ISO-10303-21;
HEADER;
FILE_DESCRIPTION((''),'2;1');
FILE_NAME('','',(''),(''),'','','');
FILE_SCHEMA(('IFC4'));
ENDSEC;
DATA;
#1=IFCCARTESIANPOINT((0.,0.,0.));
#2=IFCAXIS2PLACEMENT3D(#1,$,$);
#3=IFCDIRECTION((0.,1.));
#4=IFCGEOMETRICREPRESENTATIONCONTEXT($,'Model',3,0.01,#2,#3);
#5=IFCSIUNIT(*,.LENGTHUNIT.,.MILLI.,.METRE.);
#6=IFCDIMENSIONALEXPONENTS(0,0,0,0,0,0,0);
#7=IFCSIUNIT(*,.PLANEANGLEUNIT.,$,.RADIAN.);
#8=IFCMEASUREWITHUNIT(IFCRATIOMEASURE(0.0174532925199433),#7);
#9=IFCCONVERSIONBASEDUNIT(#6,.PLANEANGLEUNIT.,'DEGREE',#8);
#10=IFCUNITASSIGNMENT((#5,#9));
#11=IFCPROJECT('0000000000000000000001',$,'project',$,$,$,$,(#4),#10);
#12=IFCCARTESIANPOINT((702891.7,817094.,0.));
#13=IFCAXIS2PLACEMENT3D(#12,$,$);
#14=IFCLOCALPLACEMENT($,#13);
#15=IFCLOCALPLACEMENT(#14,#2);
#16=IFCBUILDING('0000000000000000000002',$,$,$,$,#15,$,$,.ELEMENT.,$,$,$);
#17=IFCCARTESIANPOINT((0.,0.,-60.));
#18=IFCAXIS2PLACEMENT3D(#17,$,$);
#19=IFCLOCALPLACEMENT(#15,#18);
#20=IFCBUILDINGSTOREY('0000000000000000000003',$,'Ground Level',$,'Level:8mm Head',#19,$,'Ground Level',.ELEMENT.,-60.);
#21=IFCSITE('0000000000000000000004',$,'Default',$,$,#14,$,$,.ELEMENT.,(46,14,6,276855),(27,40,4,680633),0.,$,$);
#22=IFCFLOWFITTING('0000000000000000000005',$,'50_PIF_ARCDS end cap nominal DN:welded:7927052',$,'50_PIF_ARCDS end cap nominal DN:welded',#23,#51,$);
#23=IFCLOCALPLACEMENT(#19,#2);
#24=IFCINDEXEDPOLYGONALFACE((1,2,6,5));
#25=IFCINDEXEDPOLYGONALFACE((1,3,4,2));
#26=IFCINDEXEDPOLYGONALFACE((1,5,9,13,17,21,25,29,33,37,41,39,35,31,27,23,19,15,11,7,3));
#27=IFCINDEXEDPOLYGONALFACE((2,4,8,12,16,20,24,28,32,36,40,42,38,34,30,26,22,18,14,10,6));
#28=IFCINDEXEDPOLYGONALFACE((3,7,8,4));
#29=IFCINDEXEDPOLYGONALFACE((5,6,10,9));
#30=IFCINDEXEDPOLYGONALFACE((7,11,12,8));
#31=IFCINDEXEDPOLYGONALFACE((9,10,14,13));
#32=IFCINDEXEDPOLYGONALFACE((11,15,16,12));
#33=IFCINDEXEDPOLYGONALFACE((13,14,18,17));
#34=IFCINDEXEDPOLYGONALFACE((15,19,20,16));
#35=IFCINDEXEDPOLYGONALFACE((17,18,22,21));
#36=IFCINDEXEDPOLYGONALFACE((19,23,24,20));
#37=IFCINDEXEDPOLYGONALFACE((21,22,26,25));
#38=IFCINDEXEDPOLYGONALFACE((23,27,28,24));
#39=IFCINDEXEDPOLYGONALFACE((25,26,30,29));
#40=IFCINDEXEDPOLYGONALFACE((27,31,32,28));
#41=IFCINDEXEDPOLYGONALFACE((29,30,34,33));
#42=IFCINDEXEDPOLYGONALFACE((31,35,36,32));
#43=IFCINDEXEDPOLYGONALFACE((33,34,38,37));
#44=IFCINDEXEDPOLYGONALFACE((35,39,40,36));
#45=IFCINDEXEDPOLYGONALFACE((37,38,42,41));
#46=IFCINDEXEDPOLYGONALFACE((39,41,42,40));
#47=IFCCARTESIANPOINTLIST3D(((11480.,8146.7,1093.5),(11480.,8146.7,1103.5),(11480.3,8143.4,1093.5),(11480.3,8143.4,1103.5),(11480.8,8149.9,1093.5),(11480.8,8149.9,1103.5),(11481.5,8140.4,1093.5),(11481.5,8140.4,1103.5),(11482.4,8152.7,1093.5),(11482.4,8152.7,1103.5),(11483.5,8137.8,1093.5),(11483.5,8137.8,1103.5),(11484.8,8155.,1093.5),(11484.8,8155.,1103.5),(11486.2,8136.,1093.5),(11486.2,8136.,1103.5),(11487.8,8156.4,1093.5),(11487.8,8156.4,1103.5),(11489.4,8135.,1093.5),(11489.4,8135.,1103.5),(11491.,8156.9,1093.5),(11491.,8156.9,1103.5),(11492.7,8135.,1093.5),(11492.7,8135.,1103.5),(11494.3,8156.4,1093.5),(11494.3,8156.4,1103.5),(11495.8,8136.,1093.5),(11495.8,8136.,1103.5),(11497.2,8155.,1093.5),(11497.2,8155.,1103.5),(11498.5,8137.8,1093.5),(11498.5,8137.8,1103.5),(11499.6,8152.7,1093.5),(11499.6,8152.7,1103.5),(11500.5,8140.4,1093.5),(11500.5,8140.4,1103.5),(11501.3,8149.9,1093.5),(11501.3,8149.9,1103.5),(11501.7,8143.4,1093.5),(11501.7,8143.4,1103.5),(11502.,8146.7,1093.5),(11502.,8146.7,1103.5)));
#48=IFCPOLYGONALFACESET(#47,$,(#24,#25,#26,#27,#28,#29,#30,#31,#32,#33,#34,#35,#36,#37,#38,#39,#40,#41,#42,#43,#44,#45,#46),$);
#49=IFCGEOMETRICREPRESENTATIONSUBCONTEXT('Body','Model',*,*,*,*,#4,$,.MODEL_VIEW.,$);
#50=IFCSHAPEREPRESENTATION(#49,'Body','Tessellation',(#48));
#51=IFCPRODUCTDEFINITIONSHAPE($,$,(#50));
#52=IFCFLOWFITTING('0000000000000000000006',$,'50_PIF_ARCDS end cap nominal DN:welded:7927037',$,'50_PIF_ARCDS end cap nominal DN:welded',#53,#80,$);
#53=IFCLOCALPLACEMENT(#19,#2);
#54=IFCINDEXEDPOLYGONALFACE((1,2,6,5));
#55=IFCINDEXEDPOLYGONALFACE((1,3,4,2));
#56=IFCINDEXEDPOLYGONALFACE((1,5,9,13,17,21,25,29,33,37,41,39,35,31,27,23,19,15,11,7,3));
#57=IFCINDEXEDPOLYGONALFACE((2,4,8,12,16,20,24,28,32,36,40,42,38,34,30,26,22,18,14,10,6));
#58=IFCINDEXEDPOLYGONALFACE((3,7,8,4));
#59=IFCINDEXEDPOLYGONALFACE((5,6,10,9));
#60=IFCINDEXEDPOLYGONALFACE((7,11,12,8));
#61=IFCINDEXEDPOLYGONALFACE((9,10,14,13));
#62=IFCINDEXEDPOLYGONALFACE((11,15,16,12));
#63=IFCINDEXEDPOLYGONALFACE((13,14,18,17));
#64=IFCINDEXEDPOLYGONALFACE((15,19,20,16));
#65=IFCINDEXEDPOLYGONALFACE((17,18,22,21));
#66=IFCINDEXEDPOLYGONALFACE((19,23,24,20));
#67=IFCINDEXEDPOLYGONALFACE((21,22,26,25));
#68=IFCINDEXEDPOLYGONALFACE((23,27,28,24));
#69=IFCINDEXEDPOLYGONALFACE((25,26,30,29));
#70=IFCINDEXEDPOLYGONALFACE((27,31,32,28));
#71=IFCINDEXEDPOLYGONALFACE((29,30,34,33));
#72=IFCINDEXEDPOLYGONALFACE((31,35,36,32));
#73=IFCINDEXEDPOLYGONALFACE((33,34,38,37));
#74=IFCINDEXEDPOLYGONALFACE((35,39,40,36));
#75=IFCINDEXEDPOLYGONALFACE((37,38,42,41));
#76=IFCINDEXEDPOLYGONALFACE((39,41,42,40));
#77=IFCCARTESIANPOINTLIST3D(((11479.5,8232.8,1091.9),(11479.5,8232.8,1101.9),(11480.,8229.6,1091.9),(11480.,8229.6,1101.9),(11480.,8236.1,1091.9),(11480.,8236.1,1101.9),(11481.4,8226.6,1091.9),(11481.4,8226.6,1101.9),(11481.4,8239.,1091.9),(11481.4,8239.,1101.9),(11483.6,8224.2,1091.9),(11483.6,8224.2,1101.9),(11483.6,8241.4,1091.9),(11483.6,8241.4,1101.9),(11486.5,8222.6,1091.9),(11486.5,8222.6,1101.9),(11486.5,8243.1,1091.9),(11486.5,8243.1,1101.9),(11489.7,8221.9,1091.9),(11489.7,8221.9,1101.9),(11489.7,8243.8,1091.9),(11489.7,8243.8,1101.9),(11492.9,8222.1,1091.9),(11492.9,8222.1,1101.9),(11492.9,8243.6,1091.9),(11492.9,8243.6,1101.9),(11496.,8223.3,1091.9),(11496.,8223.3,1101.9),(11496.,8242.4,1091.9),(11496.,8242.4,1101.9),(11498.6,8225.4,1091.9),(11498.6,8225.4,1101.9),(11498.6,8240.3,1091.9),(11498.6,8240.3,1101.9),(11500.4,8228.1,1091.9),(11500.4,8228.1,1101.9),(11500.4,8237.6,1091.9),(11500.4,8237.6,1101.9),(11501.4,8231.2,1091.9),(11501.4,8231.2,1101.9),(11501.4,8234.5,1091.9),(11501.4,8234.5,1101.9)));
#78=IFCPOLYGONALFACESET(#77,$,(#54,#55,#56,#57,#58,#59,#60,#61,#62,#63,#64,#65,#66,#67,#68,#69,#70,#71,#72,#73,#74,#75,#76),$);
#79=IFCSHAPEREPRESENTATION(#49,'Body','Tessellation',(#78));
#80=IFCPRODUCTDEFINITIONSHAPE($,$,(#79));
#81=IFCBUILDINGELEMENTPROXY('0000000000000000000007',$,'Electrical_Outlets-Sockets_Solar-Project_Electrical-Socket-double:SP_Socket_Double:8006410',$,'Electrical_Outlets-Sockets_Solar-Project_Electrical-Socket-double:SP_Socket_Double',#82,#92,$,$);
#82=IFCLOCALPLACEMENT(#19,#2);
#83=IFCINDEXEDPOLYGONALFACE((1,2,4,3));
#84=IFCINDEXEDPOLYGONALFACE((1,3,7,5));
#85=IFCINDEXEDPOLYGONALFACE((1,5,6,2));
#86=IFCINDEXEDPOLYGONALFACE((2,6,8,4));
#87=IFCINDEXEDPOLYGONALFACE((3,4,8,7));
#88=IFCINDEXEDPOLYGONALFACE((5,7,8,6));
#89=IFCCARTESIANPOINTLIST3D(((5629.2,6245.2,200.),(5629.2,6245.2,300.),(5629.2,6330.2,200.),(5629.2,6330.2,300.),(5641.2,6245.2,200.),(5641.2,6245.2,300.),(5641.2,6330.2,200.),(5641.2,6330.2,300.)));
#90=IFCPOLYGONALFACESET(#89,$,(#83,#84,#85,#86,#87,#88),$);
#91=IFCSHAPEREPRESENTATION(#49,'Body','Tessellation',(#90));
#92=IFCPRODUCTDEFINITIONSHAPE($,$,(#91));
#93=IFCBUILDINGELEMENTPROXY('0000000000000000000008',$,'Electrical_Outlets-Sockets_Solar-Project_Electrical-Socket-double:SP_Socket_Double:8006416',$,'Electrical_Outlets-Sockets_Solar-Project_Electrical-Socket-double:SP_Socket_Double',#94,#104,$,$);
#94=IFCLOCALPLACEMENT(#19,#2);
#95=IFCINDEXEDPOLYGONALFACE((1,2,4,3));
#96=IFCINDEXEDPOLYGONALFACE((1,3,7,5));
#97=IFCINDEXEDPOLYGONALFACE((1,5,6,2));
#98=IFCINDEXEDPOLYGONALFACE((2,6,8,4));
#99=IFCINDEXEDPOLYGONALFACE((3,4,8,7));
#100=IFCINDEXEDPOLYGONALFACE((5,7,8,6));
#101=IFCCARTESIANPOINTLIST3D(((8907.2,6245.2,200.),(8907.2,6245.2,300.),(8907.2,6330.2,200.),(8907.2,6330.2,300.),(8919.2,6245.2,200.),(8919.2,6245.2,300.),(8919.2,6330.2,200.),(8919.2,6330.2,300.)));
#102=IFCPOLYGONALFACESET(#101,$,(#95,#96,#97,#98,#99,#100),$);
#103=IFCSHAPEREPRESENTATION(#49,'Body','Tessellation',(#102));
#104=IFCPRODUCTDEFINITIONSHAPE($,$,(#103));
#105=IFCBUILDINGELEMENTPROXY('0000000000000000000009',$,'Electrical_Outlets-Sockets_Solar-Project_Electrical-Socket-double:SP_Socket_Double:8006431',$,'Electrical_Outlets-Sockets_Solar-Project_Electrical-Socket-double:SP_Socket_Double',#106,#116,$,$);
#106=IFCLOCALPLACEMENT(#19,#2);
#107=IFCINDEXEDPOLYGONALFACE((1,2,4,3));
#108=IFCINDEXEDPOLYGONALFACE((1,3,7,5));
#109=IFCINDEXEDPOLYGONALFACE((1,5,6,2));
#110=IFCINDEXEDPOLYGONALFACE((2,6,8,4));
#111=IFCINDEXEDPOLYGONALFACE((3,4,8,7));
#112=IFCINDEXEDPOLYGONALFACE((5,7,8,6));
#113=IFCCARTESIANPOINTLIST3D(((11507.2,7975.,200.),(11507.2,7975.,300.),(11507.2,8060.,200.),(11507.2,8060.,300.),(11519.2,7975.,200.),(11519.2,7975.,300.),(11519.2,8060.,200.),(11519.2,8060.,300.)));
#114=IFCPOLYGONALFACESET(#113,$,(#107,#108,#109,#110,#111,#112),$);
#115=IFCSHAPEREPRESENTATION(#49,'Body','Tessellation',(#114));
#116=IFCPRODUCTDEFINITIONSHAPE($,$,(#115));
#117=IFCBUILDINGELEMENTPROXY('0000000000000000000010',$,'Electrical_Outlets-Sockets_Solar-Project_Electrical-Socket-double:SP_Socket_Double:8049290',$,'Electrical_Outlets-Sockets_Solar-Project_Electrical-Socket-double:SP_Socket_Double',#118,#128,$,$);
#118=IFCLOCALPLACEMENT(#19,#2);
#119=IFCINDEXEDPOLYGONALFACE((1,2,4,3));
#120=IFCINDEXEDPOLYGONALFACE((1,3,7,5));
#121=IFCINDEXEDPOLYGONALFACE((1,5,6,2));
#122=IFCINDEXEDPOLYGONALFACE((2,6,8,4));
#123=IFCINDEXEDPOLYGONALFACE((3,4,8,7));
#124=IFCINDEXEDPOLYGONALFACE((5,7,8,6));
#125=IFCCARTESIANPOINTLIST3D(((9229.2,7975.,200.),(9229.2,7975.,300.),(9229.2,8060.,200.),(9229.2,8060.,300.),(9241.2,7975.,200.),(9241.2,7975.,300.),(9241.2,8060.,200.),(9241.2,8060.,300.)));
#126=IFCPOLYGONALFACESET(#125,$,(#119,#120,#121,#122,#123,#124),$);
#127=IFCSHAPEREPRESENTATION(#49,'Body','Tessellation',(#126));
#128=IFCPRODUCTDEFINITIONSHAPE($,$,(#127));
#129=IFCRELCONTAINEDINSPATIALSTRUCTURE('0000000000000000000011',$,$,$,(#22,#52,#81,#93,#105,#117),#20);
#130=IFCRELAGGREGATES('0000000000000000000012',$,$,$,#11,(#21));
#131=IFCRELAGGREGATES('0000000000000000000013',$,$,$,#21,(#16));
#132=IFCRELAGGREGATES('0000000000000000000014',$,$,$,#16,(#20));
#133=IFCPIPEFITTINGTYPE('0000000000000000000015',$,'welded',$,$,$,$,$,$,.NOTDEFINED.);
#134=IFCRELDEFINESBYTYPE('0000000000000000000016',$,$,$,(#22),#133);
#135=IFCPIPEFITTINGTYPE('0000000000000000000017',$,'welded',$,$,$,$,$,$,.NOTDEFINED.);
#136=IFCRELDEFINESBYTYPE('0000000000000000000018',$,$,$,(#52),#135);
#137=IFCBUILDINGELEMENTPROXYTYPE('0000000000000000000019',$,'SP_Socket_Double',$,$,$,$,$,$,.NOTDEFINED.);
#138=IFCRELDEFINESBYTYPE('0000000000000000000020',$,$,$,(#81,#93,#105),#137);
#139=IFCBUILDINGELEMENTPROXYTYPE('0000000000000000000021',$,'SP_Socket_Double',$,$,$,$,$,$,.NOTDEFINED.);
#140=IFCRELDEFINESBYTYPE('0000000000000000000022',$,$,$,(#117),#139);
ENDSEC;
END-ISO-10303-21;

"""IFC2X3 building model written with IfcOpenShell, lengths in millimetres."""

from ifc_helpers import new_model, entity, si_unit, converted_unit, direction, frame, frame_2d, origin, origin_2d_with_axis, place, context, subcontext, project, spatial, rectangle, circle, extrude, source, transform, mapped, type_object, type_shapes, element, save


model = new_model("IFC2X3")

# Units and contexts
model_context = context("Model", 3, precision=0.01, world=origin(), true_north=direction((0.0, 1.0)))
body_context = subcontext(model_context, "Body", "Model", "MODEL_VIEW")
ifc_project = project(units=[si_unit("LENGTHUNIT", "METRE", prefix="MILLI"), converted_unit("PLANEANGLEUNIT", "DEGREE", entity("IfcRatioMeasure", 0.0174532925199433), si_unit("PLANEANGLEUNIT", "RADIAN"), dimensions=[0, 0, 0, 0, 0, 0, 0])], contexts=[model_context])

# Site, building, storey
site_placement = place(None, frame((702891.7, 817094.0, 0.0)))
site = spatial("IfcSite", under=ifc_project, at=site_placement, Name="Default", CompositionType="ELEMENT", RefLatitude=(46, 14, 6, 276855), RefLongitude=(27, 40, 4, 680633), RefElevation=0.0)
building_placement = place(site_placement, origin())
building = spatial("IfcBuilding", under=site, at=building_placement, CompositionType="ELEMENT")
storey_placement = place(building_placement, frame((0.0, 0.0, -60.0)))
storey = spatial("IfcBuildingStorey", under=building, at=storey_placement, Name="Ground Level", ObjectType="Level:8mm Head", LongName="Ground Level", CompositionType="ELEMENT", Elevation=-60.0)

# Flow fittings
pipe_fitting_type_1 = type_object("IfcPipeFittingType", Name="welded", PredefinedType="NOTDEFINED")
shared_shape_1 = source(origin(), body_context, "Body", "SweptSolid", [
    extrude(circle(Radius=11.0, at=frame_2d((0.0, 0.0), x_axis=(1.0, 0.0))), frame((0.0, 0.0, 0.0), z_axis=(1.0, 0.0, 0.0), x_axis=(0.0, 1.0, 0.0)), (0.0, 0.0, 1.0), 10.0),
])
type_shapes(pipe_fitting_type_1, [shared_shape_1])
flow_fitting_1_placement = place(storey_placement, frame((11491.0, 8145.9, 1093.5), z_axis=(-1.0, 0.0, 0.0), x_axis=(0.0, 0.0, 1.0)))
element("IfcFlowFitting", 1, at=flow_fitting_1_placement, inside=storey, type_object=pipe_fitting_type_1, Name="50_PIF_ARCDS end cap nominal DN:welded:7927052", ObjectType="50_PIF_ARCDS end cap nominal DN:welded", context=body_context, shape_type="MappedRepresentation", body=[
    mapped(shared_shape_1, transform((0.0, 0.0, 0.0), scale=1.0)),
])
pipe_fitting_type_2 = type_object("IfcPipeFittingType", Name="welded", PredefinedType="NOTDEFINED")
shared_shape_2 = source(origin(), body_context, "Body", "SweptSolid", [
    extrude(circle(Radius=11.0, at=frame_2d((0.0, 0.0), x_axis=(1.0, 0.0))), frame((0.0, 0.0, 0.0), z_axis=(1.0, 0.0, 0.0), x_axis=(0.0, -1.0, 0.0)), (0.0, 0.0, 1.0), 10.0),
])
type_shapes(pipe_fitting_type_2, [shared_shape_2])
flow_fitting_2_placement = place(storey_placement, frame((11490.5, 8232.8, 1091.9), z_axis=(0.0, 1.0, 0.0), x_axis=(0.0, 0.0, 1.0)))
element("IfcFlowFitting", 2, at=flow_fitting_2_placement, inside=storey, type_object=pipe_fitting_type_2, Name="50_PIF_ARCDS end cap nominal DN:welded:7927037", ObjectType="50_PIF_ARCDS end cap nominal DN:welded", context=body_context, shape_type="MappedRepresentation", body=[
    mapped(shared_shape_2, transform((0.0, 0.0, 0.0), scale=1.0)),
])

# Building element proxies
building_element_proxy_type_1 = type_object("IfcBuildingElementProxyType", Name="SP_Socket_Double", PredefinedType="NOTDEFINED")
shared_shape_3 = source(origin(), body_context, "Body", "SweptSolid", [
    extrude(rectangle(XDim=85.0, YDim=12.0, at=origin_2d_with_axis()), frame((0.0, 6.0, -100.0), z_axis=(0.0, 0.0, 1.0), x_axis=(-1.0, 0.0, 0.0)), (0.0, 0.0, 1.0), 100.0),
])
type_shapes(building_element_proxy_type_1, [shared_shape_3])
for number, where, z_axis, x_axis, name in (
    (3, (5629.2, 6287.7, 300.0), (0.0, 0.0, 1.0), (0.0, -1.0, 0.0), "Electrical_Outlets-Sockets_Solar-Project_Electrical-Socket-double:SP_Socket_Double:8006410"),
    (4, (8919.2, 6287.7, 300.0), (0.0, 0.0, 1.0), (0.0, 1.0, 0.0), "Electrical_Outlets-Sockets_Solar-Project_Electrical-Socket-double:SP_Socket_Double:8006416"),
    (5, (11519.2, 8017.5, 300.0), (0.0, 0.0, 1.0), (0.0, 1.0, 0.0), "Electrical_Outlets-Sockets_Solar-Project_Electrical-Socket-double:SP_Socket_Double:8006431"),
):
    element("IfcBuildingElementProxy", number, at=place(storey_placement, frame(where, z_axis=z_axis, x_axis=x_axis)), inside=storey, type_object=building_element_proxy_type_1, Name=name, ObjectType="Electrical_Outlets-Sockets_Solar-Project_Electrical-Socket-double:SP_Socket_Double", context=body_context, shape_type="MappedRepresentation", body=[
        mapped(shared_shape_3, transform((0.0, 0.0, 0.0), scale=1.0)),
    ])
building_element_proxy_type_2 = type_object("IfcBuildingElementProxyType", Name="SP_Socket_Double", PredefinedType="NOTDEFINED")
shared_shape_4 = source(origin(), body_context, "Body", "SweptSolid", [
    extrude(rectangle(XDim=12.0, YDim=85.0, at=origin_2d_with_axis()), frame((0.0, -6.0, -100.0), z_axis=(0.0, 0.0, 1.0), x_axis=(0.0, 1.0, 0.0)), (0.0, 0.0, 1.0), 100.0),
])
type_shapes(building_element_proxy_type_2, [shared_shape_4])
proxy_placement = place(storey_placement, frame((9229.2, 8017.5, 300.0), z_axis=(0.0, 0.0, 1.0), x_axis=(0.0, 1.0, 0.0)))
element("IfcBuildingElementProxy", 6, at=proxy_placement, inside=storey, type_object=building_element_proxy_type_2, Name="Electrical_Outlets-Sockets_Solar-Project_Electrical-Socket-double:SP_Socket_Double:8049290", ObjectType="Electrical_Outlets-Sockets_Solar-Project_Electrical-Socket-double:SP_Socket_Double", context=body_context, shape_type="MappedRepresentation", body=[
    mapped(shared_shape_4, transform((0.0, 0.0, 0.0), scale=1.0)),
])

save(model, "model.ifc")
